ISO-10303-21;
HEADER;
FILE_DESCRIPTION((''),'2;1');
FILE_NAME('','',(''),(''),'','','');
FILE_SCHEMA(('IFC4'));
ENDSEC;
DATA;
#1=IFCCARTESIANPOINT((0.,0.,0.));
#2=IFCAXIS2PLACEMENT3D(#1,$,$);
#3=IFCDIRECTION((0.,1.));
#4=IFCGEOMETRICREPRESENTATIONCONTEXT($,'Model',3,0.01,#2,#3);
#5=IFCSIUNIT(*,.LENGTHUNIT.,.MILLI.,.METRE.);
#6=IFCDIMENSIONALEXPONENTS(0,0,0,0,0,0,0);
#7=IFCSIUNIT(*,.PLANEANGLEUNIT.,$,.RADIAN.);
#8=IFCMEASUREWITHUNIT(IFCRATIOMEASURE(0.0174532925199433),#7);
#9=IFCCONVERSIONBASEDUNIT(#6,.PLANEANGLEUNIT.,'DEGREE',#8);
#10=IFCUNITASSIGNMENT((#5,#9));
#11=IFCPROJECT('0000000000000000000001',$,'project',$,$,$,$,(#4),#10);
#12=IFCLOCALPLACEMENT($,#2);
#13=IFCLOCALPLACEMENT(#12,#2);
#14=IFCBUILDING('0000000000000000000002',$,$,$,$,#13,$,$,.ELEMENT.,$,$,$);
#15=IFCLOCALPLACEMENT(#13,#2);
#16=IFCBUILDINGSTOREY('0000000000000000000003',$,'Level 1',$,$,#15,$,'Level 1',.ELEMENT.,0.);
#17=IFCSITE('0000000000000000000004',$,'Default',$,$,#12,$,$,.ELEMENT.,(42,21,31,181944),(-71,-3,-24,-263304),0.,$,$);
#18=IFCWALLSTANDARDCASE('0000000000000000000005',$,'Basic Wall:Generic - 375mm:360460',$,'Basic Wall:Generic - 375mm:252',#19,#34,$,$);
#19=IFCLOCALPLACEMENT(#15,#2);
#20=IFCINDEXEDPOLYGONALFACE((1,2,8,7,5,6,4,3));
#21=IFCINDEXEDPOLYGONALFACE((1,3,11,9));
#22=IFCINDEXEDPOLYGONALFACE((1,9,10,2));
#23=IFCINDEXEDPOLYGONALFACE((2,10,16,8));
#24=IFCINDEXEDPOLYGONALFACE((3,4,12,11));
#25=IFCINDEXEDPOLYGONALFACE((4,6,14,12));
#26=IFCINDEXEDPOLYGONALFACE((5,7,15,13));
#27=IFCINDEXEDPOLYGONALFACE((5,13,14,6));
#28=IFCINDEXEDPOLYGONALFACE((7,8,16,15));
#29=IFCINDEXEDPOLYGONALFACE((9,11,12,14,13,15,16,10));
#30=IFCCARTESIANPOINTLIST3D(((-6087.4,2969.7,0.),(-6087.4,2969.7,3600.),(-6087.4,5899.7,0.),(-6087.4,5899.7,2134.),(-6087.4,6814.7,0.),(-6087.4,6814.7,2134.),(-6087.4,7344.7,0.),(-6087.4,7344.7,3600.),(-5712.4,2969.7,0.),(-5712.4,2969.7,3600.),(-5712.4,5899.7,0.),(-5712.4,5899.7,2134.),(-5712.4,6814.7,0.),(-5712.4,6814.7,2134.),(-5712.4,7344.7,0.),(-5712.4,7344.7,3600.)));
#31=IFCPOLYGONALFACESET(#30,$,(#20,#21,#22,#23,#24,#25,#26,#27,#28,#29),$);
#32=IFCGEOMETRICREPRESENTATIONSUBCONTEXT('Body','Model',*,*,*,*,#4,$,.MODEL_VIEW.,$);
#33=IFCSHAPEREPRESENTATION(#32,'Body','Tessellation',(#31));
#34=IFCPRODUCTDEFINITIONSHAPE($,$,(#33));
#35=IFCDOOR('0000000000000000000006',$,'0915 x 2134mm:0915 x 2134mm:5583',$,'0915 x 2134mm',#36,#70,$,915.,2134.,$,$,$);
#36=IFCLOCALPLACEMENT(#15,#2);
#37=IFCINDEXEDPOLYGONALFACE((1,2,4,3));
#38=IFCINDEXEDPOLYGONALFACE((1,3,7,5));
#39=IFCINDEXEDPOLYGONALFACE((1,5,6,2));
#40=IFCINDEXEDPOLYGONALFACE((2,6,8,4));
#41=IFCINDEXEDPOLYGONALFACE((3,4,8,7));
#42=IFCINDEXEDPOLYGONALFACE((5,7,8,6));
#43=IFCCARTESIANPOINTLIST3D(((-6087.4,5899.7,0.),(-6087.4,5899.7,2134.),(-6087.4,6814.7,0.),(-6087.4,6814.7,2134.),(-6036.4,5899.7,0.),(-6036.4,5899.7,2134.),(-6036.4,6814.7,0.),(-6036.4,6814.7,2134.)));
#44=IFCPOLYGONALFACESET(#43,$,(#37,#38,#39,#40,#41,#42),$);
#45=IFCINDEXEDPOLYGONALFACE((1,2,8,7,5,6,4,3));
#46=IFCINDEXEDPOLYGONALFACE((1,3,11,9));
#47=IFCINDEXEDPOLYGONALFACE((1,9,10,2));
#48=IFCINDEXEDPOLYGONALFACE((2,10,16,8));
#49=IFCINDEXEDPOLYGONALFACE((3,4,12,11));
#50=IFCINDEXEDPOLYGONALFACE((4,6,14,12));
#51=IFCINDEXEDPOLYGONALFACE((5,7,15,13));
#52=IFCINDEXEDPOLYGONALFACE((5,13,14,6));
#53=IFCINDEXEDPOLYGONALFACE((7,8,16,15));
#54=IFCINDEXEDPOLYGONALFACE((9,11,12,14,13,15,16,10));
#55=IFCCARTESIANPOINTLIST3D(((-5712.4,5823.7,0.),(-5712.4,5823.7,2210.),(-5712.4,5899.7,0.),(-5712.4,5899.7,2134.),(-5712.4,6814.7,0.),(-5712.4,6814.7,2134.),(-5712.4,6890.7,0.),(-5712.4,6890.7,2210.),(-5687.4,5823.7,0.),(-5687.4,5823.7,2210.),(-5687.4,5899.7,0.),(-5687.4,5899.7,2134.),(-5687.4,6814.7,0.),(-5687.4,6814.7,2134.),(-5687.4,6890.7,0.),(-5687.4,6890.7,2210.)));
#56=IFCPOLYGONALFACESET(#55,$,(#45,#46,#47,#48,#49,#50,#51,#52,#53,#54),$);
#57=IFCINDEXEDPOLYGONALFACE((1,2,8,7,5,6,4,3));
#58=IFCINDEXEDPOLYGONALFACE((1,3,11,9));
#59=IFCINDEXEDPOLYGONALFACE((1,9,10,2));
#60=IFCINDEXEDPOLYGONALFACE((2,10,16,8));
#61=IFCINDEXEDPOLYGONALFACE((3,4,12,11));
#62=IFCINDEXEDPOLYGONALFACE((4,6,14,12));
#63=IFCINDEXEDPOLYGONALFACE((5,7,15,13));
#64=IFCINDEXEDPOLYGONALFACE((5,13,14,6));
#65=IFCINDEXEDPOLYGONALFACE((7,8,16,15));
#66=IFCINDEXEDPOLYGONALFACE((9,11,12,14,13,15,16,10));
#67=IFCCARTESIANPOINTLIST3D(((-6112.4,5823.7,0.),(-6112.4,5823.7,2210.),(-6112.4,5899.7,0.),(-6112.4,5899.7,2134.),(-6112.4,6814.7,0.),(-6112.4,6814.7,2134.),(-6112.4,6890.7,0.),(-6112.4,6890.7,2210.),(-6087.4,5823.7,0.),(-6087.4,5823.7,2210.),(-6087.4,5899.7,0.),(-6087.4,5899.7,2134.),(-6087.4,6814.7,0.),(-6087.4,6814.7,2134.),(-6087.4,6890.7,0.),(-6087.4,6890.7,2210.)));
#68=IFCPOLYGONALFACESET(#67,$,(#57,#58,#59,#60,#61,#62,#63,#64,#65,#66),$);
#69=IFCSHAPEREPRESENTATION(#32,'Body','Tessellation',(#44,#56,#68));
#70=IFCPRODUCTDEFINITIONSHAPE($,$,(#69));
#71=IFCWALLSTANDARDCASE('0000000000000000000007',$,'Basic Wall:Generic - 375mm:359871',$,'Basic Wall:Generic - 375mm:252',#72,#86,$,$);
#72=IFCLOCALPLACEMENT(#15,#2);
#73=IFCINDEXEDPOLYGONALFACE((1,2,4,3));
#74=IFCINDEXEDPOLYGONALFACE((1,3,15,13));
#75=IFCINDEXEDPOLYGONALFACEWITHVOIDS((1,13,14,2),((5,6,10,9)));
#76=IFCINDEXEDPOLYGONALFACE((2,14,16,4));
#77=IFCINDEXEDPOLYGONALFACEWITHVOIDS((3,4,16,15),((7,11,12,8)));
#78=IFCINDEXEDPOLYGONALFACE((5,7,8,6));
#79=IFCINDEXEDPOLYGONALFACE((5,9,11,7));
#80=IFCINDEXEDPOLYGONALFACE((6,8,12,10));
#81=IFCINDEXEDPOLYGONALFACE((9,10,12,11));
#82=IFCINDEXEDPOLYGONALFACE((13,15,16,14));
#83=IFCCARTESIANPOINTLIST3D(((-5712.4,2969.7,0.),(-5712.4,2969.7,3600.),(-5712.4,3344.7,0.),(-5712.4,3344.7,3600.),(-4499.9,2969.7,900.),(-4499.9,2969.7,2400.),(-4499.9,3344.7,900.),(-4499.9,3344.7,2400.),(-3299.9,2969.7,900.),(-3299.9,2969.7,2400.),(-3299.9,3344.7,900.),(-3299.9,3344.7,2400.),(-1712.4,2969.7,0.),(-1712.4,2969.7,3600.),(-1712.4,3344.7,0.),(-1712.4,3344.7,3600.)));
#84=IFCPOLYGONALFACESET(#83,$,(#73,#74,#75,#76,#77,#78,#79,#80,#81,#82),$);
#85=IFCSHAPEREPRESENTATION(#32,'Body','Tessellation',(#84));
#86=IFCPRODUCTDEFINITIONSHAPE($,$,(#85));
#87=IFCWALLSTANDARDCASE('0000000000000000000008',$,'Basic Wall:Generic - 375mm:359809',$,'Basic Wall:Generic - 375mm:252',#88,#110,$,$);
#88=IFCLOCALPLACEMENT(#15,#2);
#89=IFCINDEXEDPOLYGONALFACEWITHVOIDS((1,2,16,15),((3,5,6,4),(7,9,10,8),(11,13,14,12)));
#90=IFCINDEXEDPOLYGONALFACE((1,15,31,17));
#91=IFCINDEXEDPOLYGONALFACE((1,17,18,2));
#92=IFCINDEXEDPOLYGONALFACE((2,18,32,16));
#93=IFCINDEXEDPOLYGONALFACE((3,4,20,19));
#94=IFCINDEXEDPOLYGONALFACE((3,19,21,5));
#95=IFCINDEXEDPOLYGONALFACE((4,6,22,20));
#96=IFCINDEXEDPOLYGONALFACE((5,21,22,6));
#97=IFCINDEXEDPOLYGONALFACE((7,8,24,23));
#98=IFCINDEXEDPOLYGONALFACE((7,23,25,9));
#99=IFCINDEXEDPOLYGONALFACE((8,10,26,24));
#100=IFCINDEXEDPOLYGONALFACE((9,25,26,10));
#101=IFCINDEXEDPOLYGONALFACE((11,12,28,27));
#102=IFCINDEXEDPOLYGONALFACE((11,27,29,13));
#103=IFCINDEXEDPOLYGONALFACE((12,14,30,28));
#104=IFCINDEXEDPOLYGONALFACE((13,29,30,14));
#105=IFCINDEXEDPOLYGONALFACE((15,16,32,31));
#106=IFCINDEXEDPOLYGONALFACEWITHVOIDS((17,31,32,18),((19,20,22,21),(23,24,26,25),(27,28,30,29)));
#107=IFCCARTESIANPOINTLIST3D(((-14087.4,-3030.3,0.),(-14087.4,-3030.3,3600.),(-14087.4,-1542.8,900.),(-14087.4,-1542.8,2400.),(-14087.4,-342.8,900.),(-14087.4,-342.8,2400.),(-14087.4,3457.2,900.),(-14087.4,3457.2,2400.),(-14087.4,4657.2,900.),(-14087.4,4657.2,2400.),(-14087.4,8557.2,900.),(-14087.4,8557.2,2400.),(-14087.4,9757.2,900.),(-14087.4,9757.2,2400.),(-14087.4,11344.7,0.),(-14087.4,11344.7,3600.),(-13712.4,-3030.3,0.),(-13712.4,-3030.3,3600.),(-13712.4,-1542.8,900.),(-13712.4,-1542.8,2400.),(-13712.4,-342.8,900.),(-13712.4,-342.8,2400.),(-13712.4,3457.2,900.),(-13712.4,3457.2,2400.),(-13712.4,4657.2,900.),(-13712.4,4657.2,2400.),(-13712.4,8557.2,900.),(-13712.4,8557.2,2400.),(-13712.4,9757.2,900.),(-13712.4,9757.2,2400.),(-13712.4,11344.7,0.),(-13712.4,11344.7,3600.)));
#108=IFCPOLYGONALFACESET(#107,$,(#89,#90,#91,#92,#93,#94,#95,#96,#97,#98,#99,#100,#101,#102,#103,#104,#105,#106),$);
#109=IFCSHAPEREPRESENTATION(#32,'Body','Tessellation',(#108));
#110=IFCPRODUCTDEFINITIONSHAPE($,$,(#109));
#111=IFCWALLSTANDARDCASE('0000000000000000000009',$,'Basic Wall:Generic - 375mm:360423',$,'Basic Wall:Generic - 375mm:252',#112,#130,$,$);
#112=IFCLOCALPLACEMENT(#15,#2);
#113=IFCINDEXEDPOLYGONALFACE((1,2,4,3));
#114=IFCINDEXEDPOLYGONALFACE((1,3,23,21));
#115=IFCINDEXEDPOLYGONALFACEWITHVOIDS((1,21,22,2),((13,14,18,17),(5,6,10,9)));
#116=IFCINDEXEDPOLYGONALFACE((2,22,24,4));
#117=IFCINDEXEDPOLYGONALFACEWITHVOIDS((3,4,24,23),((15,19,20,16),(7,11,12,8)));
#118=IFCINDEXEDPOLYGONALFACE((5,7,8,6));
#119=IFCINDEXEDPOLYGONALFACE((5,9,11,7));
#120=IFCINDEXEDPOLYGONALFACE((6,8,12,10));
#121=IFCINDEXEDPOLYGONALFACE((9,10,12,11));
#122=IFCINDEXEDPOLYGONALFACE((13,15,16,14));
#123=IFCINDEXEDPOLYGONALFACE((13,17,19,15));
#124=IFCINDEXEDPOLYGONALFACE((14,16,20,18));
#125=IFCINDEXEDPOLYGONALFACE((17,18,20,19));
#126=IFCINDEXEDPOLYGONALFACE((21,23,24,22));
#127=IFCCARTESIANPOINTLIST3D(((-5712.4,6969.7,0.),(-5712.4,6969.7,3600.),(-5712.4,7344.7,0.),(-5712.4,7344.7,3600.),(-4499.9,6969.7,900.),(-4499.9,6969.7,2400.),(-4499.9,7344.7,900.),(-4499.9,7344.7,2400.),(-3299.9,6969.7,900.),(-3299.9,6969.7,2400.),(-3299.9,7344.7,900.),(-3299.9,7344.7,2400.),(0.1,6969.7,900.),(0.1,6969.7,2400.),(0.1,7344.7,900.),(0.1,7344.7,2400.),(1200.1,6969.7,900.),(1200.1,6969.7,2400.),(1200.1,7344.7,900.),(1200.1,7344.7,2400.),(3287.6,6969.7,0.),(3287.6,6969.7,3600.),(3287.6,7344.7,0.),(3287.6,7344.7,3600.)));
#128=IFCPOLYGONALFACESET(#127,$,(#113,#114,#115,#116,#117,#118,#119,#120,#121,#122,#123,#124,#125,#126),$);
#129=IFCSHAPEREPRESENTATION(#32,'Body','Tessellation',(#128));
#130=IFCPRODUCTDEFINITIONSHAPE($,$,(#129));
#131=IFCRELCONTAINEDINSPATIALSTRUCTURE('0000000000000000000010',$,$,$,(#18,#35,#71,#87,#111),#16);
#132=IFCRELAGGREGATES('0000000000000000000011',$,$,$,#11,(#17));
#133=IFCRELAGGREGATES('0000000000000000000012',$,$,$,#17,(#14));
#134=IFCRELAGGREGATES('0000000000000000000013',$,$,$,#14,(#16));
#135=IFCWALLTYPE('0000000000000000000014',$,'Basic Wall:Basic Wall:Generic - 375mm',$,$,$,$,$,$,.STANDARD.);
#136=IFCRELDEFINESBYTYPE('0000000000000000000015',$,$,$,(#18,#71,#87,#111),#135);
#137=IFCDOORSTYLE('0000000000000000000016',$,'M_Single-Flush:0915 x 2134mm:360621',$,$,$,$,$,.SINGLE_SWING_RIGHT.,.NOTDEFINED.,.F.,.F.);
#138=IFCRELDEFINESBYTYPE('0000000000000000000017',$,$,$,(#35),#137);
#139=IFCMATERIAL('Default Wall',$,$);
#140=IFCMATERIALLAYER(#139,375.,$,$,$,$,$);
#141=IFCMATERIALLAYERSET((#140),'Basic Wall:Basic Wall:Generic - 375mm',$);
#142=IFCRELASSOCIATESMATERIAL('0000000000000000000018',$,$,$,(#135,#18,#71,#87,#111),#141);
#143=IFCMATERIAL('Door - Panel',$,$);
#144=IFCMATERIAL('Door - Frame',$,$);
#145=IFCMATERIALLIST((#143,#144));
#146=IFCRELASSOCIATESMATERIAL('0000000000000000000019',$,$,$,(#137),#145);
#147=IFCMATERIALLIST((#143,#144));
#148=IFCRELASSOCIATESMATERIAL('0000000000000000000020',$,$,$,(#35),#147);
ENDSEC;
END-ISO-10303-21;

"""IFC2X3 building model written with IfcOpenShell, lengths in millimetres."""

from ifc_helpers import new_model, entity, si_unit, converted_unit, direction, frame, frame_2d, origin, origin_2d_with_axis, place, context, subcontext, project, spatial, polyline, rectangle, outline, extrude, source, transform, mapped, material, material_list, layer, layer_set, layer_usage, type_object, type_shapes, element, fill, save


model = new_model("IFC2X3")

# Units and contexts
model_context = context("Model", 3, precision=0.01, world=origin(), true_north=direction((0.0, 1.0)))
body_context = subcontext(model_context, "Body", "Model", "MODEL_VIEW")
ifc_project = project(units=[si_unit("LENGTHUNIT", "METRE", prefix="MILLI"), converted_unit("PLANEANGLEUNIT", "DEGREE", entity("IfcRatioMeasure", 0.0174532925199433), si_unit("PLANEANGLEUNIT", "RADIAN"), dimensions=[0, 0, 0, 0, 0, 0, 0])], contexts=[model_context])

# Site, building, storey
site_placement = place(None, origin())
site = spatial("IfcSite", under=ifc_project, at=site_placement, Name="Default", CompositionType="ELEMENT", RefLatitude=(42, 21, 31, 181944), RefLongitude=(-71, -3, -24, -263304), RefElevation=0.0)
building_placement = place(site_placement, origin())
building = spatial("IfcBuilding", under=site, at=building_placement, CompositionType="ELEMENT")
storey_placement = place(building_placement, origin())
storey = spatial("IfcBuildingStorey", under=building, at=storey_placement, Name="Level 1", LongName="Level 1", CompositionType="ELEMENT", Elevation=0.0)

# Wall, opening, door
ifc_material_1 = material(Name="Default Wall")
ifc_layer_1 = layer(ifc_material_1, 375.0)
ifc_layer_set_1 = layer_set([ifc_layer_1], Name="Basic Wall:Basic Wall:Generic - 375mm")
ifc_layer_usage_1 = layer_usage(ifc_layer_set_1, "AXIS2", "NEGATIVE", 187.5)
wall_type_1 = type_object("IfcWallType", Name="Basic Wall:Basic Wall:Generic - 375mm", PredefinedType="STANDARD", material=ifc_layer_set_1)
wall_1_placement = place(storey_placement, frame((-5899.9, 2969.7, 0.0), z_axis=(0.0, 0.0, 1.0), x_axis=(0.0, 1.0, 0.0)))
wall_1 = element("IfcWallStandardCase", 1, at=wall_1_placement, inside=storey, type_object=wall_type_1, material=ifc_layer_usage_1, Name="Basic Wall:Generic - 375mm:360460", ObjectType="Basic Wall:Generic - 375mm:252", context=body_context, shape_type="SweptSolid", body=[
    extrude(rectangle(XDim=4375.0, YDim=375.0, at=frame_2d((2187.5, 0.0), x_axis=(-1.0, 0.0))), origin(), (0.0, 0.0, 1.0), 3600.0),
])
opening_1_placement = place(wall_1_placement, frame((-2969.7, -5899.9, 0.0), z_axis=(0.0, 0.0, 1.0), x_axis=(0.0, -1.0, 0.0)))
opening_1 = element("IfcOpeningElement", 2, at=opening_1_placement, cuts=wall_1, ObjectType="Opening", context=body_context, shape_type="SweptSolid", body=[
    extrude(rectangle(XDim=2134.0, YDim=915.0, at=origin_2d_with_axis()), frame((-5708.7, 6357.2, 1067.0), z_axis=(-1.0, 0.0, 0.0), x_axis=(0.0, 0.0, -1.0)), (0.0, 0.0, 1.0), 382.5),
])
ifc_material_2 = material(Name="Door - Panel")
ifc_material_3 = material(Name="Door - Frame")
ifc_material_list_1 = material_list([ifc_material_2, ifc_material_3])
ifc_material_list_2 = material_list([ifc_material_2, ifc_material_3])
door_style_1 = type_object("IfcDoorStyle", Name="M_Single-Flush:0915 x 2134mm:360621", ConstructionType="NOTDEFINED", OperationType="SINGLE_SWING_RIGHT", ParameterTakesPrecedence=False, Sizeable=False, material=ifc_material_list_2)
shared_shape_1 = source(origin(), body_context, "Body", "SweptSolid", [
    extrude(rectangle(XDim=915.0, YDim=51.0, at=origin_2d_with_axis()), frame((457.5, -29.3, 0.0), z_axis=(0.0, 0.0, 1.0), x_axis=(-1.0, 0.0, 0.0)), (0.0, 0.0, 1.0), 2134.0),
    extrude(outline(polyline([(-533.5, -1086.0), (-457.5, -1086.0), (-457.5, 1048.0), (457.5, 1048.0), (457.5, -1086.0), (533.5, -1086.0), (533.5, 1124.0), (-533.5, 1124.0), (-533.5, -1086.0)])), frame((457.5, -403.7, 1086.0), z_axis=(0.0, 1.0, 0.0), x_axis=(-1.0, 0.0, 0.0)), (0.0, 0.0, 1.0), 25.0),
    extrude(outline(polyline([(-1124.0, -533.5), (1086.0, -533.5), (1086.0, -457.5), (-1048.0, -457.5), (-1048.0, 457.5), (1086.0, 457.5), (1086.0, 533.5), (-1124.0, 533.5), (-1124.0, -533.5)])), frame((457.5, -3.7, 1086.0), z_axis=(0.0, 1.0, 0.0), x_axis=(0.0, 0.0, -1.0)), (0.0, 0.0, 1.0), 25.0),
])
type_shapes(door_style_1, [shared_shape_1])
door_1_placement = place(opening_1_placement, frame((-6091.2, 5899.7, 0.0), z_axis=(0.0, 0.0, 1.0), x_axis=(0.0, 1.0, 0.0)))
door_1 = element("IfcDoor", 3, at=door_1_placement, inside=storey, type_object=door_style_1, material=ifc_material_list_1, Name="0915 x 2134mm:0915 x 2134mm:5583", ObjectType="0915 x 2134mm", OverallHeight=915.0, OverallWidth=2134.0, context=body_context, shape_type="MappedRepresentation", body=[
    mapped(shared_shape_1, transform((0.0, 0.0, 0.0), scale=1.0)),
])
fill(opening_1, door_1)

# Wall, opening
ifc_layer_usage_2 = layer_usage(ifc_layer_set_1, "AXIS2", "NEGATIVE", 187.5)
wall_2_placement = place(storey_placement, frame((-1712.4, 3157.2, 0.0), z_axis=(0.0, 0.0, 1.0), x_axis=(-1.0, 0.0, 0.0)))
wall_2 = element("IfcWallStandardCase", 4, at=wall_2_placement, inside=storey, type_object=wall_type_1, material=ifc_layer_usage_2, Name="Basic Wall:Generic - 375mm:359871", ObjectType="Basic Wall:Generic - 375mm:252", context=body_context, shape_type="SweptSolid", body=[
    extrude(rectangle(XDim=4000.0, YDim=375.0, at=frame_2d((2000.0, 0.0), x_axis=(-1.0, 0.0))), origin(), (0.0, 0.0, 1.0), 3600.0),
])
opening_2_placement = place(wall_2_placement, frame((-1712.4, 3157.2, 0.0), z_axis=(0.0, 0.0, 1.0), x_axis=(-1.0, 0.0, 0.0)))
element("IfcOpeningElement", 5, at=opening_2_placement, cuts=wall_2, ObjectType="Opening", context=body_context, shape_type="SweptSolid", body=[
    extrude(rectangle(XDim=1500.0, YDim=1200.0, at=frame_2d((0.0, 0.0), x_axis=(0.0, 1.0))), frame((-3899.9, 3348.4, 1650.0), z_axis=(0.0, -1.0, 0.0), x_axis=(1.0, 0.0, 0.0)), (0.0, 0.0, 1.0), 382.5),
])

# Walls, openings
ifc_layer_usage_3 = layer_usage(ifc_layer_set_1, "AXIS2", "NEGATIVE", 187.5)
wall_3_placement = place(storey_placement, frame((-13899.9, 11344.7, 0.0), z_axis=(0.0, 0.0, 1.0), x_axis=(0.0, -1.0, 0.0)))
wall_3 = element("IfcWallStandardCase", 6, at=wall_3_placement, inside=storey, type_object=wall_type_1, material=ifc_layer_usage_3, Name="Basic Wall:Generic - 375mm:359809", ObjectType="Basic Wall:Generic - 375mm:252", context=body_context, shape_type="SweptSolid", body=[
    extrude(rectangle(XDim=14375.0, YDim=375.0, at=frame_2d((7187.5, 0.0), x_axis=(-1.0, 0.0))), origin(), (0.0, 0.0, 1.0), 3600.0),
])
opening_3_placement = place(wall_3_placement, frame((11344.7, 13899.9, 0.0), z_axis=(0.0, 0.0, 1.0), x_axis=(0.0, 1.0, 0.0)))
element("IfcOpeningElement", 7, at=opening_3_placement, cuts=wall_3, ObjectType="Opening", context=body_context, shape_type="SweptSolid", body=[
    extrude(rectangle(XDim=1500.0, YDim=1200.0, at=frame_2d((0.0, 0.0), x_axis=(0.0, 1.0))), frame((-14091.2, 9157.2, 1650.0), z_axis=(1.0, 0.0, 0.0), x_axis=(0.0, 1.0, 0.0)), (0.0, 0.0, 1.0), 382.5),
])
opening_4_placement = place(wall_3_placement, frame((11344.7, 13899.9, 0.0), z_axis=(0.0, 0.0, 1.0), x_axis=(0.0, 1.0, 0.0)))
element("IfcOpeningElement", 8, at=opening_4_placement, cuts=wall_3, ObjectType="Opening", context=body_context, shape_type="SweptSolid", body=[
    extrude(rectangle(XDim=1500.0, YDim=1200.0, at=frame_2d((0.0, 0.0), x_axis=(0.0, 1.0))), frame((-14091.2, 4057.2, 1650.0), z_axis=(1.0, 0.0, 0.0), x_axis=(0.0, 1.0, 0.0)), (0.0, 0.0, 1.0), 382.5),
])
opening_5_placement = place(wall_3_placement, frame((11344.7, 13899.9, 0.0), z_axis=(0.0, 0.0, 1.0), x_axis=(0.0, 1.0, 0.0)))
element("IfcOpeningElement", 9, at=opening_5_placement, cuts=wall_3, ObjectType="Opening", context=body_context, shape_type="SweptSolid", body=[
    extrude(rectangle(XDim=1500.0, YDim=1200.0, at=frame_2d((0.0, 0.0), x_axis=(0.0, 1.0))), frame((-14091.2, -942.8, 1650.0), z_axis=(1.0, 0.0, 0.0), x_axis=(0.0, 1.0, 0.0)), (0.0, 0.0, 1.0), 382.5),
])
ifc_layer_usage_4 = layer_usage(ifc_layer_set_1, "AXIS2", "NEGATIVE", 187.5)
wall_4_placement = place(storey_placement, frame((-5712.4, 7157.2, 0.0)))
wall_4 = element("IfcWallStandardCase", 10, at=wall_4_placement, inside=storey, type_object=wall_type_1, material=ifc_layer_usage_4, Name="Basic Wall:Generic - 375mm:360423", ObjectType="Basic Wall:Generic - 375mm:252", context=body_context, shape_type="SweptSolid", body=[
    extrude(rectangle(XDim=9000.0, YDim=375.0, at=frame_2d((4500.0, 0.0), x_axis=(-1.0, 0.0))), origin(), (0.0, 0.0, 1.0), 3600.0),
])
opening_6_placement = place(wall_4_placement, frame((5712.4, -7157.2, 0.0)))
element("IfcOpeningElement", 11, at=opening_6_placement, cuts=wall_4, ObjectType="Opening", context=body_context, shape_type="SweptSolid", body=[
    extrude(rectangle(XDim=1500.0, YDim=1200.0, at=frame_2d((0.0, 0.0), x_axis=(0.0, 1.0))), frame((-3899.9, 6965.9, 1650.0), z_axis=(0.0, 1.0, 0.0), x_axis=(-1.0, 0.0, 0.0)), (0.0, 0.0, 1.0), 382.5),
])
opening_7_placement = place(wall_4_placement, frame((5712.4, -7157.2, 0.0)))
element("IfcOpeningElement", 12, at=opening_7_placement, cuts=wall_4, ObjectType="Opening", context=body_context, shape_type="SweptSolid", body=[
    extrude(rectangle(XDim=1500.0, YDim=1200.0, at=frame_2d((0.0, 0.0), x_axis=(0.0, 1.0))), frame((600.1, 6965.9, 1650.0), z_axis=(0.0, 1.0, 0.0), x_axis=(-1.0, 0.0, 0.0)), (0.0, 0.0, 1.0), 382.5),
])

save(model, "model.ifc")
